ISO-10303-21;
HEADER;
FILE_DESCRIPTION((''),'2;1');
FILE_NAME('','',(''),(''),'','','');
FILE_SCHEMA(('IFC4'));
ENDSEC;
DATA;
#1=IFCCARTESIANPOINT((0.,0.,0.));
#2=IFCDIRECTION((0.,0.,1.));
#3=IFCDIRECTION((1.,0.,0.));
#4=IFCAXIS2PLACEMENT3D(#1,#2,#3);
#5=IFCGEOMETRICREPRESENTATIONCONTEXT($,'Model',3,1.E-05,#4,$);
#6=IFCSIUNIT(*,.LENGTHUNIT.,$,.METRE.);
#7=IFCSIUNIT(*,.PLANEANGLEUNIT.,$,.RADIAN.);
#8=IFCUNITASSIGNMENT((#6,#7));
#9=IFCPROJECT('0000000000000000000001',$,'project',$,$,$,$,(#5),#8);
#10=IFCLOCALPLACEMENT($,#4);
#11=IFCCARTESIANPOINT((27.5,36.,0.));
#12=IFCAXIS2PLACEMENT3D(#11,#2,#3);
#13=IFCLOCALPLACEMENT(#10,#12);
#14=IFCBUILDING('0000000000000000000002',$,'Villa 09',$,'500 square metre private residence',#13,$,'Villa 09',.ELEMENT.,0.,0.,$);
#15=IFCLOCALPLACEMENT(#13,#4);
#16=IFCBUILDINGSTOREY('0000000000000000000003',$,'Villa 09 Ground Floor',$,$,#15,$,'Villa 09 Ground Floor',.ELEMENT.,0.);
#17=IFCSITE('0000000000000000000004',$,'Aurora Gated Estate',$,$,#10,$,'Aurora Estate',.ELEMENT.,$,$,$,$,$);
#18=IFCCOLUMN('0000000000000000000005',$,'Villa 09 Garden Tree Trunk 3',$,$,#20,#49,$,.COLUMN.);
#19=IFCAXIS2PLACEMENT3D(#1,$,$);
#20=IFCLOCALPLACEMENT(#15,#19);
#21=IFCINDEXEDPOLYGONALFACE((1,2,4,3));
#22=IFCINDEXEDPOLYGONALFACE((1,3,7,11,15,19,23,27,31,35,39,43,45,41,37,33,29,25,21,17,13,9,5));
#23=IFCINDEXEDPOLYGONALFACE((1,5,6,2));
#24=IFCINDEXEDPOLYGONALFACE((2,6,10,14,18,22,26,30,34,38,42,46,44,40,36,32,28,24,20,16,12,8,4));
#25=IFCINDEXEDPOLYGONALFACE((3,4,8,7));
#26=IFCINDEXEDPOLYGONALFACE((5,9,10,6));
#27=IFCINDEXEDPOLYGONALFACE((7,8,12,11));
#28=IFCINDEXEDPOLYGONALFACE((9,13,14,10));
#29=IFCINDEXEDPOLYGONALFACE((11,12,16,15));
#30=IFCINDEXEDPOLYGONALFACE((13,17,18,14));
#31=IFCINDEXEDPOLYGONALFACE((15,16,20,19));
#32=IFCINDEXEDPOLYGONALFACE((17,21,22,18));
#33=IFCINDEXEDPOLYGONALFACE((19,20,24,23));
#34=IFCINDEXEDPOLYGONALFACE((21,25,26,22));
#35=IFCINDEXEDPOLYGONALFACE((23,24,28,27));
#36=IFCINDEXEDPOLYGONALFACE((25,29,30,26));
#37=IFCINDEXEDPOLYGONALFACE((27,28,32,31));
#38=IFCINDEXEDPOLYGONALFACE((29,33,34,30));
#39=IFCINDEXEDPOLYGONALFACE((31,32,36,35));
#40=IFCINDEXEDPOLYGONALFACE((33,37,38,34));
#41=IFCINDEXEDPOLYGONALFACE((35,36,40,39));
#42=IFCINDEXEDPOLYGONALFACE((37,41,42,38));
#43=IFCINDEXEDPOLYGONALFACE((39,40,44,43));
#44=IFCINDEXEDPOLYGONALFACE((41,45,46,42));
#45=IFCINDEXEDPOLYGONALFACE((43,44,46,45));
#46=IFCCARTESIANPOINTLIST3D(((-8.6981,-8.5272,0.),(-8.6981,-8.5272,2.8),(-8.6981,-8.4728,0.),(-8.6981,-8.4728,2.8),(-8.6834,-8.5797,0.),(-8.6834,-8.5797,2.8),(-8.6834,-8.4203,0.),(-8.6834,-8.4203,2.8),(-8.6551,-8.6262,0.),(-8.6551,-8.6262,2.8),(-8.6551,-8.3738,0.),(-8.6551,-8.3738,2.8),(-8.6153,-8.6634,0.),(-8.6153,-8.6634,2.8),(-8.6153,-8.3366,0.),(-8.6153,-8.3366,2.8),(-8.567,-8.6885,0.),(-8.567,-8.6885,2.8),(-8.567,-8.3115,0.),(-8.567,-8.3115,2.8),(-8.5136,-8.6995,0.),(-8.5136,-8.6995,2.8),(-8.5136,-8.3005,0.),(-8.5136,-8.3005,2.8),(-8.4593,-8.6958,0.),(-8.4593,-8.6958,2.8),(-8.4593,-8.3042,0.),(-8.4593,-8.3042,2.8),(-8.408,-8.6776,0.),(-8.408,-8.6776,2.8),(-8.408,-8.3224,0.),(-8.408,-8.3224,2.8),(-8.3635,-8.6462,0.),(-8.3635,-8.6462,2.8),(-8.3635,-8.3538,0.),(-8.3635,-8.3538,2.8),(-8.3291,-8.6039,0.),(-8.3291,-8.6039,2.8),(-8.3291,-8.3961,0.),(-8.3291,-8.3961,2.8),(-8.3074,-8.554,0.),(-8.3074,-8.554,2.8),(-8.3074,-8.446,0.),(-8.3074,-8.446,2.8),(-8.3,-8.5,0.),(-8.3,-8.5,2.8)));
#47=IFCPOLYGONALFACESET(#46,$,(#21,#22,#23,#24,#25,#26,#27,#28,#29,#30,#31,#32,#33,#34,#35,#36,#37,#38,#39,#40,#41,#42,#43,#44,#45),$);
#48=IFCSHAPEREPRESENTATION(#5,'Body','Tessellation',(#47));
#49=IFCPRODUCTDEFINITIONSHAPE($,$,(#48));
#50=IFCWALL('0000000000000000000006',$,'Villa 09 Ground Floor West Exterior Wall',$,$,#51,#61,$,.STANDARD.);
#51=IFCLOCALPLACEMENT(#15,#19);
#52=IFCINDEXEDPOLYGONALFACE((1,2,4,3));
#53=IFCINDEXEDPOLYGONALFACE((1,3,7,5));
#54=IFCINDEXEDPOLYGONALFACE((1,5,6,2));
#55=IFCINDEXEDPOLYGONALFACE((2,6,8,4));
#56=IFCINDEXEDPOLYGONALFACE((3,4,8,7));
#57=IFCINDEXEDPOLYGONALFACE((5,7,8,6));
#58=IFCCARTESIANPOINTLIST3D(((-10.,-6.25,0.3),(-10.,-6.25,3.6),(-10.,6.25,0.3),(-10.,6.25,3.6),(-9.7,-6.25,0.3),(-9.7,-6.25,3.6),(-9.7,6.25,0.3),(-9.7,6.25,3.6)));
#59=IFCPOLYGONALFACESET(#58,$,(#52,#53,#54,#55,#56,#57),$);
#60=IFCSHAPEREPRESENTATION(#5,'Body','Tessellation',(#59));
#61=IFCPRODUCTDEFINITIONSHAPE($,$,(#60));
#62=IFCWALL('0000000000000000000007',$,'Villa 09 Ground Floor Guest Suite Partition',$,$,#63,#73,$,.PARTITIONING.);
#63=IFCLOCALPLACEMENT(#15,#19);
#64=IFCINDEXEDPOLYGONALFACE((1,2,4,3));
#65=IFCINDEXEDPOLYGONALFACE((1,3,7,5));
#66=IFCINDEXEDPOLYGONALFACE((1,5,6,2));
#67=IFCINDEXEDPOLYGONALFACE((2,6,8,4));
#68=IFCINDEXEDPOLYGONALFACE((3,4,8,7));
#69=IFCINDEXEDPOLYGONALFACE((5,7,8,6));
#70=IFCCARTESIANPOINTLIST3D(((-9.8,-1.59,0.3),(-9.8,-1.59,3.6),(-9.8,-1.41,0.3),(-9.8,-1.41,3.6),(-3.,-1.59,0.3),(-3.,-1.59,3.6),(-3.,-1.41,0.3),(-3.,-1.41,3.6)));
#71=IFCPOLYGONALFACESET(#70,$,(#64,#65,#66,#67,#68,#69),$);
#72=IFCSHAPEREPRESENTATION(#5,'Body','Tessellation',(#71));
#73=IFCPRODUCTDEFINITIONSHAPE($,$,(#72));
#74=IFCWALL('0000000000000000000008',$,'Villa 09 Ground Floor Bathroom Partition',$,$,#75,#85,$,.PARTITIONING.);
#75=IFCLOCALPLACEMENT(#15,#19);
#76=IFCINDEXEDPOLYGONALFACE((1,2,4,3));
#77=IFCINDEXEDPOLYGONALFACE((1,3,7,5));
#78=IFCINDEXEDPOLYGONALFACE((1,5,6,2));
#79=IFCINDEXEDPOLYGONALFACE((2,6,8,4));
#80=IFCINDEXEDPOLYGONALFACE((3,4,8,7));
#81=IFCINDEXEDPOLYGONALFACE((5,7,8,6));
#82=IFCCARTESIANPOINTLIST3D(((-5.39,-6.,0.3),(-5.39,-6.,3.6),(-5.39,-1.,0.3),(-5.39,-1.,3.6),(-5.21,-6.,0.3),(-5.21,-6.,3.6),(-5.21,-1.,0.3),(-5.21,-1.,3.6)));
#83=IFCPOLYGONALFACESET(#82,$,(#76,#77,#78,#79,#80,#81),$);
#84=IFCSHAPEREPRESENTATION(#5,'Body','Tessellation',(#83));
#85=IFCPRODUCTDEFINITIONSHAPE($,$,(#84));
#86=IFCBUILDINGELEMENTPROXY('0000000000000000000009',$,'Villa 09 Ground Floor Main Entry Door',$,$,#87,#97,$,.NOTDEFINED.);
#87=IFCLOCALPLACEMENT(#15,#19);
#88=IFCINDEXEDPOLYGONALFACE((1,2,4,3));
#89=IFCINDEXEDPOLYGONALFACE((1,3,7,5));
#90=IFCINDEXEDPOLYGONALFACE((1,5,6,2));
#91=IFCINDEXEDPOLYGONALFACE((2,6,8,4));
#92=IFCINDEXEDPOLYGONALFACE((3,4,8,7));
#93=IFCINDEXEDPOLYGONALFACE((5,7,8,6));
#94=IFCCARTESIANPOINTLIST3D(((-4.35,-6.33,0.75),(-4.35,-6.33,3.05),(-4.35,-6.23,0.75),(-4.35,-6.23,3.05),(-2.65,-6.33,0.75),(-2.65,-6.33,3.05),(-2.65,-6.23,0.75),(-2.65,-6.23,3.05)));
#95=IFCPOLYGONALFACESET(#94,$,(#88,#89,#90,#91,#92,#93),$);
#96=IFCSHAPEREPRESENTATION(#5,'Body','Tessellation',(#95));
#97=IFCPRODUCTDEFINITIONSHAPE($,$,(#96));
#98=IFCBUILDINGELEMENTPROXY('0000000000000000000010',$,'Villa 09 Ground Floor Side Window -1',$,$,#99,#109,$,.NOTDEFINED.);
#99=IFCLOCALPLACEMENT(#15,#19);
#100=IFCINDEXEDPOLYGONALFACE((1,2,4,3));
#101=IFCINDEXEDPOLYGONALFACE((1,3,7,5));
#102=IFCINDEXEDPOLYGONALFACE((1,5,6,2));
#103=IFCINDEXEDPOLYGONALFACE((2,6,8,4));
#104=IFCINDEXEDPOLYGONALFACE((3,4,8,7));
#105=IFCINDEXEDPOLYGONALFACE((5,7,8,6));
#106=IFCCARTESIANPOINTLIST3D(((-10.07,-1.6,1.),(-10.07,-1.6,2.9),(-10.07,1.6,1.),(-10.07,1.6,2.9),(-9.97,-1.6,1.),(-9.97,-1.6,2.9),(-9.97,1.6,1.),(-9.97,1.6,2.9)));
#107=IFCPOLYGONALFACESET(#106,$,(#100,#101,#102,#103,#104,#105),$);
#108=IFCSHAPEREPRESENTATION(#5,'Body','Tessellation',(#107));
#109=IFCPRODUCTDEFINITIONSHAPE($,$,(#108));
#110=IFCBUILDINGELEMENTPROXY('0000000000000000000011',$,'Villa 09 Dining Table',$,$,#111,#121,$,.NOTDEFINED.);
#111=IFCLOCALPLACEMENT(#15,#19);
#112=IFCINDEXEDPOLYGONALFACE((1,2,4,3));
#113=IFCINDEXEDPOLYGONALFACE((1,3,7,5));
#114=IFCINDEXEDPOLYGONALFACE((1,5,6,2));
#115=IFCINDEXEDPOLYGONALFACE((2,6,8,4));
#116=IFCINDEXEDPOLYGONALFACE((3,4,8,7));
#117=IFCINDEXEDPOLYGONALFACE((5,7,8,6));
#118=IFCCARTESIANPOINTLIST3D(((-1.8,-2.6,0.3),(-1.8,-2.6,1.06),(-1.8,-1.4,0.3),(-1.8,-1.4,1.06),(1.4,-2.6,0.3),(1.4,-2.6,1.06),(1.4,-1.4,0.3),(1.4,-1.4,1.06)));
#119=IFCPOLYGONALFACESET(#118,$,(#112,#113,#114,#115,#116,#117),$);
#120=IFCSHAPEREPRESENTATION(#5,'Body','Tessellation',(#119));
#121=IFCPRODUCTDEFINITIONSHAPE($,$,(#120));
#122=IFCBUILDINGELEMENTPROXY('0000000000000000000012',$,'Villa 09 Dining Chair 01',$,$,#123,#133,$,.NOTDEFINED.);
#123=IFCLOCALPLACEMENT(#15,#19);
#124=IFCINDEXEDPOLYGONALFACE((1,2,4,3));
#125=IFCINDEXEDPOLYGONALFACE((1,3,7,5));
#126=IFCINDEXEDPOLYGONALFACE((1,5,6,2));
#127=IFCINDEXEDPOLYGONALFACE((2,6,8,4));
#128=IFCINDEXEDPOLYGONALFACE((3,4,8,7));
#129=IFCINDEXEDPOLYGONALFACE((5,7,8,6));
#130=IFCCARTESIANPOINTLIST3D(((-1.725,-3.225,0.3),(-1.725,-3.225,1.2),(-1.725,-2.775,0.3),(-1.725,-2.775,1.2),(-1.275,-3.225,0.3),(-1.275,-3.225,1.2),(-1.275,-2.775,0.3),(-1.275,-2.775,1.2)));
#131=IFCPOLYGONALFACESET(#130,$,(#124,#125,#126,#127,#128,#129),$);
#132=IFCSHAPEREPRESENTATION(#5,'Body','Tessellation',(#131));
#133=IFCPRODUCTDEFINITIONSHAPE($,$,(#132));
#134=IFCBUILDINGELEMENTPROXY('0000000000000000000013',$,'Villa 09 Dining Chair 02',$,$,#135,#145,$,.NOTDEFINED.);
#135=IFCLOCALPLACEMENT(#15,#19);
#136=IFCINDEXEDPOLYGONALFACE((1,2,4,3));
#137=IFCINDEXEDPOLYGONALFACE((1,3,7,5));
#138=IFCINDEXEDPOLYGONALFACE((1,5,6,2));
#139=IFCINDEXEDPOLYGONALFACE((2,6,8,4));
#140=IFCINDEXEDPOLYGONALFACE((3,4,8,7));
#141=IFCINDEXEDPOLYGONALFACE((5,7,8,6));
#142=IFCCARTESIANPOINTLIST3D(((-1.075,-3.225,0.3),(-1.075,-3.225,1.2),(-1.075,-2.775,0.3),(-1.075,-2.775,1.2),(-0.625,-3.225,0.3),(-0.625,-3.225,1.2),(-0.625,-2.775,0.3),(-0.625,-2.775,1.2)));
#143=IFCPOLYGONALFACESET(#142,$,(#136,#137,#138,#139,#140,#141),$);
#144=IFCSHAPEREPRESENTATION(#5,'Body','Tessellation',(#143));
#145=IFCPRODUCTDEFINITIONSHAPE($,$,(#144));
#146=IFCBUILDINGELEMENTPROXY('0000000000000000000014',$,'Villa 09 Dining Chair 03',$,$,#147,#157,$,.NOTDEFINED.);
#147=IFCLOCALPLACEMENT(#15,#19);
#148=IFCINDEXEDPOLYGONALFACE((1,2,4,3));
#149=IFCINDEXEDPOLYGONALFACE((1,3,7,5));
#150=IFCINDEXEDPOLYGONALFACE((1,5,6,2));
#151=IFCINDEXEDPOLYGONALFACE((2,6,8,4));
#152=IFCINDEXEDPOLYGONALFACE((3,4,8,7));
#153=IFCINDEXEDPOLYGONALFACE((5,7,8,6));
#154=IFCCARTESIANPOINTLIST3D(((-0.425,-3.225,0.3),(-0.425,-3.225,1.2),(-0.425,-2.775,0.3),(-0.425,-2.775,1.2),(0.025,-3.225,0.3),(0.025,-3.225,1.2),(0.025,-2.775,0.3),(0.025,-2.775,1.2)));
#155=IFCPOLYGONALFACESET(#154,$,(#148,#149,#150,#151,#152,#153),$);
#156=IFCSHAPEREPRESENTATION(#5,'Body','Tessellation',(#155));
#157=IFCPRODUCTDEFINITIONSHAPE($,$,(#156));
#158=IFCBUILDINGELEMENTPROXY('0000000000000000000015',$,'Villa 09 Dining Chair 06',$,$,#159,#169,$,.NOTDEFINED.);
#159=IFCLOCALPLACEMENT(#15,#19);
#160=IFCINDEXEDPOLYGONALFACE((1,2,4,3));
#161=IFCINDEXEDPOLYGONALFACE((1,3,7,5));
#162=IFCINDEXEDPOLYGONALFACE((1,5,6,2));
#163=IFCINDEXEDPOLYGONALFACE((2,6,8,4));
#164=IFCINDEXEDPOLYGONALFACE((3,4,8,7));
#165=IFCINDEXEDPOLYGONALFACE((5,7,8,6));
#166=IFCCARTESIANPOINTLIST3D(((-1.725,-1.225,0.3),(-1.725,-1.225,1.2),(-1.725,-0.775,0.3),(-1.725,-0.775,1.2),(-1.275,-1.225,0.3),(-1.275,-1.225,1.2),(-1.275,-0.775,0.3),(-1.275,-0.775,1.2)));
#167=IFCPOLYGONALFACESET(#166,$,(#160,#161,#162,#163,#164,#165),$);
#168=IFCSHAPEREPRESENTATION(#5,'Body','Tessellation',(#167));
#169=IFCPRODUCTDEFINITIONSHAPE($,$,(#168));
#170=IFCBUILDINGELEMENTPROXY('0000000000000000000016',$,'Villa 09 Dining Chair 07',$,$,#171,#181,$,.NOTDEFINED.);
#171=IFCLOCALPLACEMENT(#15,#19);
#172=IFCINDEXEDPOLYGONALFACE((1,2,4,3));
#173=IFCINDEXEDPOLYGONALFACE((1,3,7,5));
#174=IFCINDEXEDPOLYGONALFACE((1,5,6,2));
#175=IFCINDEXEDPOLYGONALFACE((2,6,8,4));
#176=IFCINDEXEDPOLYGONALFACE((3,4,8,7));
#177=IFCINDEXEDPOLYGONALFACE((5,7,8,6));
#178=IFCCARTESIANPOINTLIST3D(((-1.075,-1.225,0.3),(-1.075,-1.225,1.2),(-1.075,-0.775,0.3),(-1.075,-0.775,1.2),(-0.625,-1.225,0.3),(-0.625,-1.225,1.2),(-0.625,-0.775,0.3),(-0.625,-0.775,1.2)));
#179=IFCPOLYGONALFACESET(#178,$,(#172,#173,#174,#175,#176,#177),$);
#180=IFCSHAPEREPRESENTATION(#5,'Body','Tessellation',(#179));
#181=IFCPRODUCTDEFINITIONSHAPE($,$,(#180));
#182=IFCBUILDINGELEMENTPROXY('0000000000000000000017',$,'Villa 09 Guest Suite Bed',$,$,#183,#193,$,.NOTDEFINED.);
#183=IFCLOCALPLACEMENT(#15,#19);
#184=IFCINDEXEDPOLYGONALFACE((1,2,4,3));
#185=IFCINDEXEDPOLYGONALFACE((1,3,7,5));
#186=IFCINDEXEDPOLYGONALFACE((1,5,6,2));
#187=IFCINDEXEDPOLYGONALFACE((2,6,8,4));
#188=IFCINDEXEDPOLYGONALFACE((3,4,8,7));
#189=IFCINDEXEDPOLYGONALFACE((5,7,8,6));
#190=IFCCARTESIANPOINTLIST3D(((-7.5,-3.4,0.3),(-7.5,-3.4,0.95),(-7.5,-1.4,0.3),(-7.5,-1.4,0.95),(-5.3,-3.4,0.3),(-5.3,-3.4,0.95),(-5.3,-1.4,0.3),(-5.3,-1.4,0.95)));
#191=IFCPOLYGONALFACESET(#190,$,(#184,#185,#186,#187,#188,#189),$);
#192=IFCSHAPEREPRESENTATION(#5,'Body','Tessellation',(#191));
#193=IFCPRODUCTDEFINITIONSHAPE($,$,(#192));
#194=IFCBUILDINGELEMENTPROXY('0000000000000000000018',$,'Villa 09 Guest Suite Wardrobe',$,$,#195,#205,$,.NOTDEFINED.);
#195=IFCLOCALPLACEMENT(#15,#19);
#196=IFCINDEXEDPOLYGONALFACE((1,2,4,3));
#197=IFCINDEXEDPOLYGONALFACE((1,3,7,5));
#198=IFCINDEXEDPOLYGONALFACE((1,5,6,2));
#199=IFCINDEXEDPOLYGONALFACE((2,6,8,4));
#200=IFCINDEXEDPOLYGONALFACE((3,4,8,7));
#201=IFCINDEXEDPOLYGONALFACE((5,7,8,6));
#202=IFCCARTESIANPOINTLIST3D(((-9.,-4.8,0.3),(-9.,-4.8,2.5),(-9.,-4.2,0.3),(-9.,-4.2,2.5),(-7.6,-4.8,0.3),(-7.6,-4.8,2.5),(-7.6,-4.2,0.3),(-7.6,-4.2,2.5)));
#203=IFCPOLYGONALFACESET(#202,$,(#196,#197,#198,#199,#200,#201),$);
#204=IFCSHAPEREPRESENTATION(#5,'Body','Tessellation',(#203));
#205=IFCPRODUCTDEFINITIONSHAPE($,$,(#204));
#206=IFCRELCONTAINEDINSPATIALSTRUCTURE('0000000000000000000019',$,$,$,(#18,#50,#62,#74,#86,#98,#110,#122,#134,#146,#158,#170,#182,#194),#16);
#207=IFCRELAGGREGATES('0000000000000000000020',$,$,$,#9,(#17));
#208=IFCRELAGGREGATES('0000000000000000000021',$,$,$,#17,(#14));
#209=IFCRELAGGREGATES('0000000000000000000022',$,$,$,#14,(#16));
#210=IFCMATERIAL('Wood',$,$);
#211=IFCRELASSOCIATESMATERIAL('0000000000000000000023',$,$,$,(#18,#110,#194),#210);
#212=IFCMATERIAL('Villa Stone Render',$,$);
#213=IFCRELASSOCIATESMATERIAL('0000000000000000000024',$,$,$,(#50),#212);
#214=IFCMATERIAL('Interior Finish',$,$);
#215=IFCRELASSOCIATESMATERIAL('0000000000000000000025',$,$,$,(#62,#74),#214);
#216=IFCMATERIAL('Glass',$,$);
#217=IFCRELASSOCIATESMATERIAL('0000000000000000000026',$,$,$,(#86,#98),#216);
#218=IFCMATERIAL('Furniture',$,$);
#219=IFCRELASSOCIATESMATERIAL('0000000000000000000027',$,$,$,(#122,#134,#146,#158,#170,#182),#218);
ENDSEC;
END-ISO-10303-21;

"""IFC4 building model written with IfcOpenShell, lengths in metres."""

from ifc_helpers import new_model, si_unit, frame, origin_with_axes, origin_2d_with_axis, place, context, project, spatial, rectangle, circle, extrude, material, element, save


model = new_model("IFC4")

# Units and contexts
model_context = context("Model", 3, precision=1e-05, world=origin_with_axes())
ifc_project = project(units=[si_unit("LENGTHUNIT", "METRE"), si_unit("PLANEANGLEUNIT", "RADIAN")], contexts=[model_context])

# Site, building, storey
site_placement = place(None, origin_with_axes())
site = spatial("IfcSite", under=ifc_project, at=site_placement, Name="Aurora Gated Estate", LongName="Aurora Estate", CompositionType="ELEMENT")
building_placement = place(site_placement, frame((27.5, 36.0, 0.0), z_axis=(0.0, 0.0, 1.0), x_axis=(1.0, 0.0, 0.0)))
building = spatial("IfcBuilding", under=site, at=building_placement, Name="Villa 09", ObjectType="500 square metre private residence", LongName="Villa 09", CompositionType="ELEMENT", ElevationOfRefHeight=0.0, ElevationOfTerrain=0.0)
storey_placement = place(building_placement, origin_with_axes())
storey = spatial("IfcBuildingStorey", under=building, at=storey_placement, Name="Villa 09 Ground Floor", LongName="Villa 09 Ground Floor", CompositionType="ELEMENT", Elevation=0.0)

# Column
ifc_material_1 = material(Name="Wood")
column_placement = place(storey_placement, frame((-8.5, -8.5, 0.0), z_axis=(0.0, 0.0, 1.0), x_axis=(1.0, 0.0, 0.0)))
element("IfcColumn", 1, at=column_placement, inside=storey, material=ifc_material_1, Name="Villa 09 Garden Tree Trunk 3", PredefinedType="COLUMN", context=model_context, shape_type="SweptSolid", body=[
    extrude(circle(Radius=0.2, at=origin_2d_with_axis()), origin_with_axes(), (0.0, 0.0, 1.0), 2.8),
])

# Walls
ifc_material_2 = material(Name="Villa Stone Render")
wall_1_placement = place(storey_placement, frame((-9.85, 0.0, 0.3), z_axis=(0.0, 0.0, 1.0), x_axis=(1.0, 0.0, 0.0)))
element("IfcWall", 2, at=wall_1_placement, inside=storey, material=ifc_material_2, Name="Villa 09 Ground Floor West Exterior Wall", PredefinedType="STANDARD", context=model_context, shape_type="SweptSolid", body=[
    extrude(rectangle(XDim=0.3, YDim=12.5, at=origin_2d_with_axis()), origin_with_axes(), (0.0, 0.0, 1.0), 3.3),
])
ifc_material_3 = material(Name="Interior Finish")
wall_2_placement = place(storey_placement, frame((-6.4, -1.5, 0.3), z_axis=(0.0, 0.0, 1.0), x_axis=(1.0, 0.0, 0.0)))
element("IfcWall", 3, at=wall_2_placement, inside=storey, material=ifc_material_3, Name="Villa 09 Ground Floor Guest Suite Partition", PredefinedType="PARTITIONING", context=model_context, shape_type="SweptSolid", body=[
    extrude(rectangle(XDim=6.8, YDim=0.18, at=origin_2d_with_axis()), origin_with_axes(), (0.0, 0.0, 1.0), 3.3),
])
wall_3_placement = place(storey_placement, frame((-5.3, -3.5, 0.3), z_axis=(0.0, 0.0, 1.0), x_axis=(1.0, 0.0, 0.0)))
element("IfcWall", 4, at=wall_3_placement, inside=storey, material=ifc_material_3, Name="Villa 09 Ground Floor Bathroom Partition", PredefinedType="PARTITIONING", context=model_context, shape_type="SweptSolid", body=[
    extrude(rectangle(XDim=0.18, YDim=5.0, at=origin_2d_with_axis()), origin_with_axes(), (0.0, 0.0, 1.0), 3.3),
])

# Building element proxies
ifc_material_4 = material(Name="Glass")
proxy_1_placement = place(storey_placement, frame((-3.5, -6.28, 0.75), z_axis=(0.0, 0.0, 1.0), x_axis=(1.0, 0.0, 0.0)))
element("IfcBuildingElementProxy", 5, at=proxy_1_placement, inside=storey, material=ifc_material_4, Name="Villa 09 Ground Floor Main Entry Door", PredefinedType="NOTDEFINED", context=model_context, shape_type="SweptSolid", body=[
    extrude(rectangle(XDim=1.7, YDim=0.1, at=origin_2d_with_axis()), origin_with_axes(), (0.0, 0.0, 1.0), 2.3),
])
proxy_2_placement = place(storey_placement, frame((-10.02, 0.0, 1.0), z_axis=(0.0, 0.0, 1.0), x_axis=(0.0, 1.0, 0.0)))
element("IfcBuildingElementProxy", 6, at=proxy_2_placement, inside=storey, material=ifc_material_4, Name="Villa 09 Ground Floor Side Window -1", PredefinedType="NOTDEFINED", context=model_context, shape_type="SweptSolid", body=[
    extrude(rectangle(XDim=3.2, YDim=0.1, at=origin_2d_with_axis()), origin_with_axes(), (0.0, 0.0, 1.0), 1.9),
])
proxy_3_placement = place(storey_placement, frame((-0.2, -2.0, 0.3), z_axis=(0.0, 0.0, 1.0), x_axis=(1.0, 0.0, 0.0)))
element("IfcBuildingElementProxy", 7, at=proxy_3_placement, inside=storey, material=ifc_material_1, Name="Villa 09 Dining Table", PredefinedType="NOTDEFINED", context=model_context, shape_type="SweptSolid", body=[
    extrude(rectangle(XDim=3.2, YDim=1.2, at=origin_2d_with_axis()), origin_with_axes(), (0.0, 0.0, 1.0), 0.76),
])
ifc_material_5 = material(Name="Furniture")
for number, where, z_axis, x_axis, name in (
    (8, (-1.5, -3.0, 0.3), (0.0, 0.0, 1.0), (1.0, 0.0, 0.0), "Villa 09 Dining Chair 01"),
    (9, (-0.85, -3.0, 0.3), (0.0, 0.0, 1.0), (1.0, 0.0, 0.0), "Villa 09 Dining Chair 02"),
    (10, (-0.2, -3.0, 0.3), (0.0, 0.0, 1.0), (1.0, 0.0, 0.0), "Villa 09 Dining Chair 03"),
    (11, (-1.5, -1.0, 0.3), (0.0, 0.0, 1.0), (1.0, 0.0, 0.0), "Villa 09 Dining Chair 06"),
    (12, (-0.85, -1.0, 0.3), (0.0, 0.0, 1.0), (1.0, 0.0, 0.0), "Villa 09 Dining Chair 07"),
):
    element("IfcBuildingElementProxy", number, at=place(storey_placement, frame(where, z_axis=z_axis, x_axis=x_axis)), inside=storey, material=ifc_material_5, Name=name, PredefinedType="NOTDEFINED", context=model_context, shape_type="SweptSolid", body=[
        extrude(rectangle(XDim=0.45, YDim=0.45, at=origin_2d_with_axis()), origin_with_axes(), (0.0, 0.0, 1.0), 0.9),
    ])
proxy_4_placement = place(storey_placement, frame((-6.4, -2.4, 0.3), z_axis=(0.0, 0.0, 1.0), x_axis=(1.0, 0.0, 0.0)))
element("IfcBuildingElementProxy", 13, at=proxy_4_placement, inside=storey, material=ifc_material_5, Name="Villa 09 Guest Suite Bed", PredefinedType="NOTDEFINED", context=model_context, shape_type="SweptSolid", body=[
    extrude(rectangle(XDim=2.2, YDim=2.0, at=origin_2d_with_axis()), origin_with_axes(), (0.0, 0.0, 1.0), 0.65),
])
proxy_5_placement = place(storey_placement, frame((-8.3, -4.5, 0.3), z_axis=(0.0, 0.0, 1.0), x_axis=(1.0, 0.0, 0.0)))
element("IfcBuildingElementProxy", 14, at=proxy_5_placement, inside=storey, material=ifc_material_1, Name="Villa 09 Guest Suite Wardrobe", PredefinedType="NOTDEFINED", context=model_context, shape_type="SweptSolid", body=[
    extrude(rectangle(XDim=1.4, YDim=0.6, at=origin_2d_with_axis()), origin_with_axes(), (0.0, 0.0, 1.0), 2.2),
])

save(model, "model.ifc")
